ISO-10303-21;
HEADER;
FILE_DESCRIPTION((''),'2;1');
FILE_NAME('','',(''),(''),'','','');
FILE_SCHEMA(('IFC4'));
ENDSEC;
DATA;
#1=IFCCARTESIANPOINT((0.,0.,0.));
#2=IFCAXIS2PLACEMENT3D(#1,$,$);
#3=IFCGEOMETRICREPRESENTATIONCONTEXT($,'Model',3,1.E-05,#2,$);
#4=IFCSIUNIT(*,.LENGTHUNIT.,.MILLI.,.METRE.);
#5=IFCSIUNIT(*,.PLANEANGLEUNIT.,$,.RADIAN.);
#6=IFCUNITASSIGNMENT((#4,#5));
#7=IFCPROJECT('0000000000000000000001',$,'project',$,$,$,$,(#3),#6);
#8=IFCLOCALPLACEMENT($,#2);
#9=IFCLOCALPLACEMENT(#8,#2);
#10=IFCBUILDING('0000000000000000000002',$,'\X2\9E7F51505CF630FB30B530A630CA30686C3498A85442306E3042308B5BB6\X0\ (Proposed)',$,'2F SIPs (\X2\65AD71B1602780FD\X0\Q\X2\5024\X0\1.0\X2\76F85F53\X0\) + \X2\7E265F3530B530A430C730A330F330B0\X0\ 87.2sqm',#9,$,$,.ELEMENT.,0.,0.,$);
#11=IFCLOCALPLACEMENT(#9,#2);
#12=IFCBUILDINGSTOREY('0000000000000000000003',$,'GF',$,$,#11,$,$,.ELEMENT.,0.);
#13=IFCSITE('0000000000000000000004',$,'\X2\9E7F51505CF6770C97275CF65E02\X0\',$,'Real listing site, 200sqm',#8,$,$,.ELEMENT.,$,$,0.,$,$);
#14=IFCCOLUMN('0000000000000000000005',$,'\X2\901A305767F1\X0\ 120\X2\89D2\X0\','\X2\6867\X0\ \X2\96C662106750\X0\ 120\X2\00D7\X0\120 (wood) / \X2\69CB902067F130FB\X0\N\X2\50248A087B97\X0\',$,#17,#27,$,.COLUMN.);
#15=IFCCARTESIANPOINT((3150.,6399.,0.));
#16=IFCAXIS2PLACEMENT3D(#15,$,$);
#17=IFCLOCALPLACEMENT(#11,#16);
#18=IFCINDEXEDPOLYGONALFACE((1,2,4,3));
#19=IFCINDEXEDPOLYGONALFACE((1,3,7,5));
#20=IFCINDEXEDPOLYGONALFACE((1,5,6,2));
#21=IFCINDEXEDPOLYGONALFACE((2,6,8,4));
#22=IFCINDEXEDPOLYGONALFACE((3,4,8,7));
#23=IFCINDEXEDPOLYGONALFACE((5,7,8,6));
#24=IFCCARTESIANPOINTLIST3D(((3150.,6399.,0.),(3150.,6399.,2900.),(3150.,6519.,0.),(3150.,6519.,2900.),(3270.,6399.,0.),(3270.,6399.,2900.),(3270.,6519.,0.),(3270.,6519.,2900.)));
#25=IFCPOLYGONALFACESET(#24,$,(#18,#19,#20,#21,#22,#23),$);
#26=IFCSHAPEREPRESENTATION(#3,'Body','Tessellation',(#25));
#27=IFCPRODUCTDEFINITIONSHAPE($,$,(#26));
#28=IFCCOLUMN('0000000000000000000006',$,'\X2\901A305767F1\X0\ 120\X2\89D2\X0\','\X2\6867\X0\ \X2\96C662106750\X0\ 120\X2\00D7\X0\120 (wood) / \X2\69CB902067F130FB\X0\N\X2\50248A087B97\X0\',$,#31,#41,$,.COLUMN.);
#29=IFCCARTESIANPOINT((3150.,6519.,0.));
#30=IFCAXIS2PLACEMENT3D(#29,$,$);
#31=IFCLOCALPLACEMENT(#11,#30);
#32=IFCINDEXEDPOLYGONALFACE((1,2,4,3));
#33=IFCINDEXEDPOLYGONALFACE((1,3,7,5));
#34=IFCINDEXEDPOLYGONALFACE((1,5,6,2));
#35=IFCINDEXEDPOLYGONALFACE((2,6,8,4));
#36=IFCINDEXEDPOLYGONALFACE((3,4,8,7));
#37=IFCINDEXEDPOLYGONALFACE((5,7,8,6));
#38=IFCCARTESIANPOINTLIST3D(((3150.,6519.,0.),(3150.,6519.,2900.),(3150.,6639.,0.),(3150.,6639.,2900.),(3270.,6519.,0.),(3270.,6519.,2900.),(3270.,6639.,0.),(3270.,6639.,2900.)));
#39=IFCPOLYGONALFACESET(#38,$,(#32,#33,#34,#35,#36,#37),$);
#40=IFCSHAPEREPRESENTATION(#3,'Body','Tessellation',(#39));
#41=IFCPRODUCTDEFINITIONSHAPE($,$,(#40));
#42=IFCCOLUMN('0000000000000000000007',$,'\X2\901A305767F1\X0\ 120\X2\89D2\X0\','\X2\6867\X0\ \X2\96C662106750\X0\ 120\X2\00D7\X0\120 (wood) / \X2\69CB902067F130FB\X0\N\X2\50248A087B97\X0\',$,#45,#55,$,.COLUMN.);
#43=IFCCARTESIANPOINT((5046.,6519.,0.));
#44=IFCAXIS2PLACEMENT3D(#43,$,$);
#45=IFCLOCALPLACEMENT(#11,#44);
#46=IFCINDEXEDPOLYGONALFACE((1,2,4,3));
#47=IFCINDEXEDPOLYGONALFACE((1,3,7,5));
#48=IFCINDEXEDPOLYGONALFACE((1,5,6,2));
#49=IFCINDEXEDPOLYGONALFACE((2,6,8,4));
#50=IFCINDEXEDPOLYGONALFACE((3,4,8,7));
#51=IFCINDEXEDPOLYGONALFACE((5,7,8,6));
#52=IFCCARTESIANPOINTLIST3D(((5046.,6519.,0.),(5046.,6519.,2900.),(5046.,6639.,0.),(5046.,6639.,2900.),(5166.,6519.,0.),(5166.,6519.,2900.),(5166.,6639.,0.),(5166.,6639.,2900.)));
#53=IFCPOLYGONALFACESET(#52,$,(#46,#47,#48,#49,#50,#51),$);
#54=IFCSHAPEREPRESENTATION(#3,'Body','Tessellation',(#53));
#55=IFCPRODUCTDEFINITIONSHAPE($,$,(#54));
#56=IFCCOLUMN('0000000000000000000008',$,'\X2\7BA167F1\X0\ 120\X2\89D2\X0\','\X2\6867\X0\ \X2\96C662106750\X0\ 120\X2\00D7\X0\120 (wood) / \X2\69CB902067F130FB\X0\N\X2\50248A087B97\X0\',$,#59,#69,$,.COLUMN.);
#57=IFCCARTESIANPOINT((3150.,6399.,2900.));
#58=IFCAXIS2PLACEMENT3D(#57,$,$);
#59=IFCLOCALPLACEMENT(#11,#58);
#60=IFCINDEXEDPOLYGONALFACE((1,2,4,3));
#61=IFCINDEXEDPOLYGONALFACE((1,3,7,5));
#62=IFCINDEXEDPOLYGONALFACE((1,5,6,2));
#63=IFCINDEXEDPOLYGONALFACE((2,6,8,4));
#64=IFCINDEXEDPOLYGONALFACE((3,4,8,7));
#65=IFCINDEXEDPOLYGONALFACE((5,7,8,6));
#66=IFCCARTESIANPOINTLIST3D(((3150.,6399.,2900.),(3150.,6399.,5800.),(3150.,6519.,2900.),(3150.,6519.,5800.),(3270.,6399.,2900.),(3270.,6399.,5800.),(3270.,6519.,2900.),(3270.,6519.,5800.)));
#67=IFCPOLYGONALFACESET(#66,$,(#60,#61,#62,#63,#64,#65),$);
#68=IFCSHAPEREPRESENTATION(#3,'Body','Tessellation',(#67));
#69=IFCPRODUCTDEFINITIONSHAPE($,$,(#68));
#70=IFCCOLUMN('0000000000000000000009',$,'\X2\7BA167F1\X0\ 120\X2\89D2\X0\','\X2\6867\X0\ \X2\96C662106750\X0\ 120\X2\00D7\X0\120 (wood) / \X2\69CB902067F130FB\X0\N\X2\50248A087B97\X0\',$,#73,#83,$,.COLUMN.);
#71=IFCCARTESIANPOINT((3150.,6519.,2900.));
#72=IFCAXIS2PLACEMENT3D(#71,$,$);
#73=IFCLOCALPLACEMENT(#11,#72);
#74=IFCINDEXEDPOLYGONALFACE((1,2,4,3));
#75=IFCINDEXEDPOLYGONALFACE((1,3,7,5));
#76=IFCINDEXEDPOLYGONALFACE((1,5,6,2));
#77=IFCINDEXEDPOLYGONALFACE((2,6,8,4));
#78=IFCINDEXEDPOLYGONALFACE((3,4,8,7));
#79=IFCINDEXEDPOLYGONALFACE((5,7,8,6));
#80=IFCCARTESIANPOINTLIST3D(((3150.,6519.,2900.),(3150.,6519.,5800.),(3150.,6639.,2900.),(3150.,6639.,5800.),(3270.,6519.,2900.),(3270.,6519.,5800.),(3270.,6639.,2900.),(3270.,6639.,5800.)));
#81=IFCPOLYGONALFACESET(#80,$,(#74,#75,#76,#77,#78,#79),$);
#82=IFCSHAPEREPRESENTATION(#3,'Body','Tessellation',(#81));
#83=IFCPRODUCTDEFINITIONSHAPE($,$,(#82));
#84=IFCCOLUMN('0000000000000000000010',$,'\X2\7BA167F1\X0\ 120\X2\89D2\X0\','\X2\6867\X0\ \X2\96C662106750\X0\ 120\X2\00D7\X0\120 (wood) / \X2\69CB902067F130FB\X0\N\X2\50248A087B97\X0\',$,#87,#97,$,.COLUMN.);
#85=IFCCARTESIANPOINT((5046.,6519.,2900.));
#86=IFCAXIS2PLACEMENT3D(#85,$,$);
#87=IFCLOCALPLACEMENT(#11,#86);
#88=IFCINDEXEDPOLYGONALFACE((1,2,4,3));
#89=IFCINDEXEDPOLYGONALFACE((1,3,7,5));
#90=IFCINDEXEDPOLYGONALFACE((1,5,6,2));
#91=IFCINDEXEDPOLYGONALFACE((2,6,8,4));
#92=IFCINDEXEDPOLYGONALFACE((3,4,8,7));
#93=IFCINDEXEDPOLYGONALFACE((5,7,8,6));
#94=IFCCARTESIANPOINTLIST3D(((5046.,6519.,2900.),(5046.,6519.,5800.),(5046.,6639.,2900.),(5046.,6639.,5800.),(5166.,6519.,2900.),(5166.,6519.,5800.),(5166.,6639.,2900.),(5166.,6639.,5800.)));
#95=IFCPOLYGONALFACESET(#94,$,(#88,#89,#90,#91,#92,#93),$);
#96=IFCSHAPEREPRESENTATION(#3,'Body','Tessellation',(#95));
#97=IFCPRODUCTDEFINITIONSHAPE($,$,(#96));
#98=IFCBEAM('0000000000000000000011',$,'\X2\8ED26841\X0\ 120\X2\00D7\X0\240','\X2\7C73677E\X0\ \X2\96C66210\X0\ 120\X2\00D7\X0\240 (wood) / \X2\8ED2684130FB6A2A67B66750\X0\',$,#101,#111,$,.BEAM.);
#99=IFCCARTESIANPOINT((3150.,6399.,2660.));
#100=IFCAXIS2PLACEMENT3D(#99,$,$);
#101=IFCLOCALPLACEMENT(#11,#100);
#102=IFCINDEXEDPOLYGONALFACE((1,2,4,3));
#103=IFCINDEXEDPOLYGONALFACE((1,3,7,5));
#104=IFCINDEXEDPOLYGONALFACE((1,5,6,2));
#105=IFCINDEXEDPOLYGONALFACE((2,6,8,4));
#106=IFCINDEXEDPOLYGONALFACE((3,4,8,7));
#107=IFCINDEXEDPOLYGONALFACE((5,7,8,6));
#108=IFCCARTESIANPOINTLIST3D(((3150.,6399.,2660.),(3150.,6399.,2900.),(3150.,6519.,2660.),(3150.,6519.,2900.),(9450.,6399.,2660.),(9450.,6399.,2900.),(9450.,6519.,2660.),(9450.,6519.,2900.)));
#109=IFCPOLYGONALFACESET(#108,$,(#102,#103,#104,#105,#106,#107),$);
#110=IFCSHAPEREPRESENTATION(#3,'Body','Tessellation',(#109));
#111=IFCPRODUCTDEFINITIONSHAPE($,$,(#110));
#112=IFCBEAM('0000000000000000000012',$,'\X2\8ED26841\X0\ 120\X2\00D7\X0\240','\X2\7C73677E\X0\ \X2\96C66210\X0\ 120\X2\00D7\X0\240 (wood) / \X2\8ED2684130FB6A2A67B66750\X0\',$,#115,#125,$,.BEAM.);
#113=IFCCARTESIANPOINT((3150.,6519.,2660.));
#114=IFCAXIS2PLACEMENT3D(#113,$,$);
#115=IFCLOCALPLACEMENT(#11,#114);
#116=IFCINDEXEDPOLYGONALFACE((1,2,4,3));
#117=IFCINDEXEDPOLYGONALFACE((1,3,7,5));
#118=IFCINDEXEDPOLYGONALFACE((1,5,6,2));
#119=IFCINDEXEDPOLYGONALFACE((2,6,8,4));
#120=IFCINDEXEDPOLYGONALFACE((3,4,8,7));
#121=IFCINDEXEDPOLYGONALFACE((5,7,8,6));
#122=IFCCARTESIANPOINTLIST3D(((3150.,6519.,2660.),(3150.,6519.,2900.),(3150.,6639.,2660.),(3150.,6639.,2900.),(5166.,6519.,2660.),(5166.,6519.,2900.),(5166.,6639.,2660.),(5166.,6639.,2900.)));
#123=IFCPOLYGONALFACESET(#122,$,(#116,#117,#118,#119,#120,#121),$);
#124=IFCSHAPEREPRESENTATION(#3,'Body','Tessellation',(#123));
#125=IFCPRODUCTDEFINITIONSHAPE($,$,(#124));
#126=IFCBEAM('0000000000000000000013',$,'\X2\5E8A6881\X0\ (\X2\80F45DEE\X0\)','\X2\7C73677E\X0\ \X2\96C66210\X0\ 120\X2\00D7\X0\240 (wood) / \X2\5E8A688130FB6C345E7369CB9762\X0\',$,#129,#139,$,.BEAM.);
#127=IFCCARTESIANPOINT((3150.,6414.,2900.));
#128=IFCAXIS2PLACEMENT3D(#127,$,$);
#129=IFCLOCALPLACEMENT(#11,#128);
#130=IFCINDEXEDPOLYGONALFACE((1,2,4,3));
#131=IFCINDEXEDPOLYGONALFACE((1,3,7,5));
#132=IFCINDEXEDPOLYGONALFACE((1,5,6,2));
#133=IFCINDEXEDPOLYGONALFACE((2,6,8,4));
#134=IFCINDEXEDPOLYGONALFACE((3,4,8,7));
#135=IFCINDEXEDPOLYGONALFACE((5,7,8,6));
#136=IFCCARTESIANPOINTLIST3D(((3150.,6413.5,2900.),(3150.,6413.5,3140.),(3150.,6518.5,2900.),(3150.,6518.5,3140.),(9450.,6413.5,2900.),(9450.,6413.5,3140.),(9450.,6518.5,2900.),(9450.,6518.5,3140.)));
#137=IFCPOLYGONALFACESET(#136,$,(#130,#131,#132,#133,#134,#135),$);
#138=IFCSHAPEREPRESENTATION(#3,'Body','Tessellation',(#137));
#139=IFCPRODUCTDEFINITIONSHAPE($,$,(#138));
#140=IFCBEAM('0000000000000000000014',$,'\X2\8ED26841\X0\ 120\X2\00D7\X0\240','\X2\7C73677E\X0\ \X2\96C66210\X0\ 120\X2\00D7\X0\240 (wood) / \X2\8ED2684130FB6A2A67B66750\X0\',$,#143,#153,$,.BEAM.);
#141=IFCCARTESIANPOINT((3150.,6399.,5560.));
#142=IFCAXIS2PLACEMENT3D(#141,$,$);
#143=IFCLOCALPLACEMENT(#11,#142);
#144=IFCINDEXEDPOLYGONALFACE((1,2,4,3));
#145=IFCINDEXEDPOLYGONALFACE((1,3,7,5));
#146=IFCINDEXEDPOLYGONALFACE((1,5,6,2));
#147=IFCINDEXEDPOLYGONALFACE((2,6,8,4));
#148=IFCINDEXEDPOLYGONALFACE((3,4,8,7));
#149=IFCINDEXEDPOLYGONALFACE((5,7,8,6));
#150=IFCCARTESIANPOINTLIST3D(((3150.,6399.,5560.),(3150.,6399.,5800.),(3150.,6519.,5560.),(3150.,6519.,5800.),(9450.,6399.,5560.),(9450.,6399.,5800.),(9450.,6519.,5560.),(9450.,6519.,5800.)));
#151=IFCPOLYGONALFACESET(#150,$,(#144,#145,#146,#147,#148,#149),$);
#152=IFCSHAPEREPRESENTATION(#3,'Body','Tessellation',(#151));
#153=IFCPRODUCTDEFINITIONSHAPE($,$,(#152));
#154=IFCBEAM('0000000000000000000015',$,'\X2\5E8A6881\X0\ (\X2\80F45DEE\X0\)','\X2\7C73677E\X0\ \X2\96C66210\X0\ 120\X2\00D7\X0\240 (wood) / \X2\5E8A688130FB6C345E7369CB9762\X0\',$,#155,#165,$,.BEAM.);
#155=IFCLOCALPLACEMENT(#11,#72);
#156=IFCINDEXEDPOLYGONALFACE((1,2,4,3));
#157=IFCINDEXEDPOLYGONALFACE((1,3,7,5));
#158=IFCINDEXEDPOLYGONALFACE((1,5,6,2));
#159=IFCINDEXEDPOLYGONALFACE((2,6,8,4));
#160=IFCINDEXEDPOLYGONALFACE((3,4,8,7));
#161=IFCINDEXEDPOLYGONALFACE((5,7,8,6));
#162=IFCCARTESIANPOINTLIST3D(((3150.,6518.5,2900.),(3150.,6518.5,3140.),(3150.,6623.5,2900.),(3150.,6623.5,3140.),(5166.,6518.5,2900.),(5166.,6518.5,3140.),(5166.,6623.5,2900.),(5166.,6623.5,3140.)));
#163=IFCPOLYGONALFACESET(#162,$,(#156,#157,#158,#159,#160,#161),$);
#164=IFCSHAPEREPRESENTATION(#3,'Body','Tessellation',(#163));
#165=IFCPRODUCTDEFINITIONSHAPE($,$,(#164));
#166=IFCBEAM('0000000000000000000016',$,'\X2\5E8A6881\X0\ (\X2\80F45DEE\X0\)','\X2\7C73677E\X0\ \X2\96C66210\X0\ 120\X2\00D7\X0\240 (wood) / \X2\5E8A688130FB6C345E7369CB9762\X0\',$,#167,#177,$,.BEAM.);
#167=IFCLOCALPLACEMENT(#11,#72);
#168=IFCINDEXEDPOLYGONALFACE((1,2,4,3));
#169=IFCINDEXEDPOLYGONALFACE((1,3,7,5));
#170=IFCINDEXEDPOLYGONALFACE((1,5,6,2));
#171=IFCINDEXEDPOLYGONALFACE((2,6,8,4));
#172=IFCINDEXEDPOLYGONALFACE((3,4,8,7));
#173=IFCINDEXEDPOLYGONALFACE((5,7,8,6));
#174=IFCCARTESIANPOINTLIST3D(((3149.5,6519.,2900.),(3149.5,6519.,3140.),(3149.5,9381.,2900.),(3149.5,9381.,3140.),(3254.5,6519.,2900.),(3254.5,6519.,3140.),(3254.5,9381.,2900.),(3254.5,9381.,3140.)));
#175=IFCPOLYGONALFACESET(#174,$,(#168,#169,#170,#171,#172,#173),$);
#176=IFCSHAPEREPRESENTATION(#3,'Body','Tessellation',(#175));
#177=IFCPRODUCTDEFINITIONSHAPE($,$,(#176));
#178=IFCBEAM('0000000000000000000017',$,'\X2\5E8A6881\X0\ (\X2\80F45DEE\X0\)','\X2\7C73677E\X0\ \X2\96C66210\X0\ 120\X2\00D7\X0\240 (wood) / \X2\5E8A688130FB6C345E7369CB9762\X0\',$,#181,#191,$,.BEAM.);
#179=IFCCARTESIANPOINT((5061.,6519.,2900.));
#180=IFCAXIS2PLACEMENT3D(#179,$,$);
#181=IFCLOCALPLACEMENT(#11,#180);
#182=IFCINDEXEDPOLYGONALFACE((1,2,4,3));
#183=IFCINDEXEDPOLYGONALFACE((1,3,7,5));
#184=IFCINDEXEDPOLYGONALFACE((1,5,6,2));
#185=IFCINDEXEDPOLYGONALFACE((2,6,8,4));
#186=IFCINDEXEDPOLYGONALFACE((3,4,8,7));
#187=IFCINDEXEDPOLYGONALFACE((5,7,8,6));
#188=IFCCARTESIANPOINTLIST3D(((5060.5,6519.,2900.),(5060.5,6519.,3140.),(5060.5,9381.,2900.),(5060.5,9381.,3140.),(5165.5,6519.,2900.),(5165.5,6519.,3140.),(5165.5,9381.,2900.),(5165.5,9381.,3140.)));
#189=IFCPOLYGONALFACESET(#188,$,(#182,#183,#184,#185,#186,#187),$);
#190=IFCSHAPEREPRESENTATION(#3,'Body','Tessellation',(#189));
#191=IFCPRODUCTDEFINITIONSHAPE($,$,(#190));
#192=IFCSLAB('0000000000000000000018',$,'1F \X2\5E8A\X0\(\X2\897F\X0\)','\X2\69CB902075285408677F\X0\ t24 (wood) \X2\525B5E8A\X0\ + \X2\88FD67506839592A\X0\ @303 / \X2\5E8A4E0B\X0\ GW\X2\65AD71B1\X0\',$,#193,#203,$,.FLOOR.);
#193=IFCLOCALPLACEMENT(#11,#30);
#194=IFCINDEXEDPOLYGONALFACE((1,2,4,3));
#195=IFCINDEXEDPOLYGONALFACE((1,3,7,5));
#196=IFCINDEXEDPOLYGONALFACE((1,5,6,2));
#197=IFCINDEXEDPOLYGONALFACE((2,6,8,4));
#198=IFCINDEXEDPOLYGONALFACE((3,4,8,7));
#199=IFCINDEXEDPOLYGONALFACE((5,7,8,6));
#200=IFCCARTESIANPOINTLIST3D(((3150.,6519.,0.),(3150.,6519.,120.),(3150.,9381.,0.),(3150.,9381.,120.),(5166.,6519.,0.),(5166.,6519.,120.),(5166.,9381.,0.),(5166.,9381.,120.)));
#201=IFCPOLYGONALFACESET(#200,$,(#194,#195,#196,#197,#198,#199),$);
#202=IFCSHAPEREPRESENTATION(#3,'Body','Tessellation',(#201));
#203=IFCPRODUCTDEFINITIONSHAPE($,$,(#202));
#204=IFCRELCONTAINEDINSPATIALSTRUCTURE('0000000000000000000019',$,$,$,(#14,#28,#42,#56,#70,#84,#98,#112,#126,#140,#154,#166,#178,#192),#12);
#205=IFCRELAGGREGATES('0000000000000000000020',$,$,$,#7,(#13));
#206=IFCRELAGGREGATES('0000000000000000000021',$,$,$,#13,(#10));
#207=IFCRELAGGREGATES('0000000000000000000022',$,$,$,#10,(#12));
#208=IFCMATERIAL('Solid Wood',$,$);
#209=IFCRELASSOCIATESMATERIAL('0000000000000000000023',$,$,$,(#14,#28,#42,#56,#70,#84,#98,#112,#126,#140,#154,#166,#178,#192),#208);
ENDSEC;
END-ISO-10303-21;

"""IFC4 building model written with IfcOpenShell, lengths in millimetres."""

from ifc_helpers import new_model, si_unit, frame, frame_2d, origin, place, context, project, spatial, rectangle, extrude, material, element, save


model = new_model("IFC4")

# Units and contexts
model_context = context("Model", 3, precision=1e-05, world=origin())
ifc_project = project(units=[si_unit("LENGTHUNIT", "METRE", prefix="MILLI"), si_unit("PLANEANGLEUNIT", "RADIAN")], contexts=[model_context])

# Site, building, storey
site_placement = place(None, origin())
site = spatial("IfcSite", under=ifc_project, at=site_placement, Name="鹿児島県霧島市", ObjectType="Real listing site, 200sqm", CompositionType="ELEMENT", RefElevation=0.0)
building_placement = place(site_placement, origin())
building = spatial("IfcBuilding", under=site, at=building_placement, Name="鹿児島・サウナと水風呂のある家 (Proposed)", ObjectType="2F SIPs (断熱性能Q値1.0相当) + 縦張サイディング 87.2sqm", CompositionType="ELEMENT", ElevationOfRefHeight=0.0, ElevationOfTerrain=0.0)
storey_placement = place(building_placement, origin())
storey = spatial("IfcBuildingStorey", under=building, at=storey_placement, Name="GF", CompositionType="ELEMENT", Elevation=0.0)

# Columns
ifc_material_1 = material(Name="Solid Wood")
column_1_placement = place(storey_placement, frame((3150.0, 6399.0, 0.0)))
element("IfcColumn", 1, at=column_1_placement, inside=storey, material=ifc_material_1, Name="通し柱 120角", Description="桧 集成材 120×120 (wood) / 構造柱・N値計算", PredefinedType="COLUMN", context=model_context, shape_type="SweptSolid", body=[
    extrude(rectangle(XDim=120.0, YDim=120.0, at=frame_2d((60.0, 60.0))), frame((3150.0, 6399.0, 0.0)), (0.0, 0.0, 1.0), 2900.0),
])
column_2_placement = place(storey_placement, frame((3150.0, 6519.0, 0.0)))
element("IfcColumn", 2, at=column_2_placement, inside=storey, material=ifc_material_1, Name="通し柱 120角", Description="桧 集成材 120×120 (wood) / 構造柱・N値計算", PredefinedType="COLUMN", context=model_context, shape_type="SweptSolid", body=[
    extrude(rectangle(XDim=120.0, YDim=120.0, at=frame_2d((60.0, 60.0))), frame((3150.0, 6519.0, 0.0)), (0.0, 0.0, 1.0), 2900.0),
])
column_3_placement = place(storey_placement, frame((5046.0, 6519.0, 0.0)))
element("IfcColumn", 3, at=column_3_placement, inside=storey, material=ifc_material_1, Name="通し柱 120角", Description="桧 集成材 120×120 (wood) / 構造柱・N値計算", PredefinedType="COLUMN", context=model_context, shape_type="SweptSolid", body=[
    extrude(rectangle(XDim=120.0, YDim=120.0, at=frame_2d((60.0, 60.0))), frame((5046.0, 6519.0, 0.0)), (0.0, 0.0, 1.0), 2900.0),
])
column_4_placement = place(storey_placement, frame((3150.0, 6399.0, 2900.0)))
element("IfcColumn", 4, at=column_4_placement, inside=storey, material=ifc_material_1, Name="管柱 120角", Description="桧 集成材 120×120 (wood) / 構造柱・N値計算", PredefinedType="COLUMN", context=model_context, shape_type="SweptSolid", body=[
    extrude(rectangle(XDim=120.0, YDim=120.0, at=frame_2d((60.0, 60.0))), frame((3150.0, 6399.0, 2900.0)), (0.0, 0.0, 1.0), 2900.0),
])
column_5_placement = place(storey_placement, frame((3150.0, 6519.0, 2900.0)))
element("IfcColumn", 5, at=column_5_placement, inside=storey, material=ifc_material_1, Name="管柱 120角", Description="桧 集成材 120×120 (wood) / 構造柱・N値計算", PredefinedType="COLUMN", context=model_context, shape_type="SweptSolid", body=[
    extrude(rectangle(XDim=120.0, YDim=120.0, at=frame_2d((60.0, 60.0))), frame((3150.0, 6519.0, 2900.0)), (0.0, 0.0, 1.0), 2900.0),
])
column_6_placement = place(storey_placement, frame((5046.0, 6519.0, 2900.0)))
element("IfcColumn", 6, at=column_6_placement, inside=storey, material=ifc_material_1, Name="管柱 120角", Description="桧 集成材 120×120 (wood) / 構造柱・N値計算", PredefinedType="COLUMN", context=model_context, shape_type="SweptSolid", body=[
    extrude(rectangle(XDim=120.0, YDim=120.0, at=frame_2d((60.0, 60.0))), frame((5046.0, 6519.0, 2900.0)), (0.0, 0.0, 1.0), 2900.0),
])

# Beams
beam_1_placement = place(storey_placement, frame((3150.0, 6399.0, 2660.0)))
element("IfcBeam", 7, at=beam_1_placement, inside=storey, material=ifc_material_1, Name="軒桁 120×240", Description="米松 集成 120×240 (wood) / 軒桁・横架材", PredefinedType="BEAM", context=model_context, shape_type="SweptSolid", body=[
    extrude(rectangle(XDim=6300.0, YDim=120.0, at=frame_2d((3150.0, 60.0))), frame((3150.0, 6399.0, 2660.0)), (0.0, 0.0, 1.0), 240.0),
])
beam_2_placement = place(storey_placement, frame((3150.0, 6519.0, 2660.0)))
element("IfcBeam", 8, at=beam_2_placement, inside=storey, material=ifc_material_1, Name="軒桁 120×240", Description="米松 集成 120×240 (wood) / 軒桁・横架材", PredefinedType="BEAM", context=model_context, shape_type="SweptSolid", body=[
    extrude(rectangle(XDim=2016.0, YDim=120.0, at=frame_2d((1008.0, 60.0))), frame((3150.0, 6519.0, 2660.0)), (0.0, 0.0, 1.0), 240.0),
])
beam_3_placement = place(storey_placement, frame((3150.0, 6414.0, 2900.0)))
element("IfcBeam", 9, at=beam_3_placement, inside=storey, material=ifc_material_1, Name="床梁 (胴差)", Description="米松 集成 120×240 (wood) / 床梁・水平構面", PredefinedType="BEAM", context=model_context, shape_type="SweptSolid", body=[
    extrude(rectangle(XDim=6300.0, YDim=105.0, at=frame_2d((3150.0, 52.0))), frame((3150.0, 6414.0, 2900.0)), (0.0, 0.0, 1.0), 240.0),
])
beam_4_placement = place(storey_placement, frame((3150.0, 6399.0, 5560.0)))
element("IfcBeam", 10, at=beam_4_placement, inside=storey, material=ifc_material_1, Name="軒桁 120×240", Description="米松 集成 120×240 (wood) / 軒桁・横架材", PredefinedType="BEAM", context=model_context, shape_type="SweptSolid", body=[
    extrude(rectangle(XDim=6300.0, YDim=120.0, at=frame_2d((3150.0, 60.0))), frame((3150.0, 6399.0, 5560.0)), (0.0, 0.0, 1.0), 240.0),
])
beam_5_placement = place(storey_placement, frame((3150.0, 6519.0, 2900.0)))
element("IfcBeam", 11, at=beam_5_placement, inside=storey, material=ifc_material_1, Name="床梁 (胴差)", Description="米松 集成 120×240 (wood) / 床梁・水平構面", PredefinedType="BEAM", context=model_context, shape_type="SweptSolid", body=[
    extrude(rectangle(XDim=2016.0, YDim=105.0, at=frame_2d((1008.0, 52.0))), frame((3150.0, 6519.0, 2900.0)), (0.0, 0.0, 1.0), 240.0),
])
beam_6_placement = place(storey_placement, frame((3150.0, 6519.0, 2900.0)))
element("IfcBeam", 12, at=beam_6_placement, inside=storey, material=ifc_material_1, Name="床梁 (胴差)", Description="米松 集成 120×240 (wood) / 床梁・水平構面", PredefinedType="BEAM", context=model_context, shape_type="SweptSolid", body=[
    extrude(rectangle(XDim=105.0, YDim=2862.0, at=frame_2d((52.0, 1431.0))), frame((3150.0, 6519.0, 2900.0)), (0.0, 0.0, 1.0), 240.0),
])
beam_7_placement = place(storey_placement, frame((5061.0, 6519.0, 2900.0)))
element("IfcBeam", 13, at=beam_7_placement, inside=storey, material=ifc_material_1, Name="床梁 (胴差)", Description="米松 集成 120×240 (wood) / 床梁・水平構面", PredefinedType="BEAM", context=model_context, shape_type="SweptSolid", body=[
    extrude(rectangle(XDim=105.0, YDim=2862.0, at=frame_2d((52.0, 1431.0))), frame((5061.0, 6519.0, 2900.0)), (0.0, 0.0, 1.0), 240.0),
])

# Slab
slab_1_placement = place(storey_placement, frame((3150.0, 6519.0, 0.0)))
element("IfcSlab", 14, at=slab_1_placement, inside=storey, material=ifc_material_1, Name="1F 床(西)", Description="構造用合板 t24 (wood) 剛床 + 製材根太 @303 / 床下 GW断熱", PredefinedType="FLOOR", context=model_context, shape_type="SweptSolid", body=[
    extrude(rectangle(XDim=2016.0, YDim=2862.0, at=frame_2d((1008.0, 1431.0))), frame((3150.0, 6519.0, 0.0)), (0.0, 0.0, 1.0), 120.0),
])

save(model, "model.ifc")
